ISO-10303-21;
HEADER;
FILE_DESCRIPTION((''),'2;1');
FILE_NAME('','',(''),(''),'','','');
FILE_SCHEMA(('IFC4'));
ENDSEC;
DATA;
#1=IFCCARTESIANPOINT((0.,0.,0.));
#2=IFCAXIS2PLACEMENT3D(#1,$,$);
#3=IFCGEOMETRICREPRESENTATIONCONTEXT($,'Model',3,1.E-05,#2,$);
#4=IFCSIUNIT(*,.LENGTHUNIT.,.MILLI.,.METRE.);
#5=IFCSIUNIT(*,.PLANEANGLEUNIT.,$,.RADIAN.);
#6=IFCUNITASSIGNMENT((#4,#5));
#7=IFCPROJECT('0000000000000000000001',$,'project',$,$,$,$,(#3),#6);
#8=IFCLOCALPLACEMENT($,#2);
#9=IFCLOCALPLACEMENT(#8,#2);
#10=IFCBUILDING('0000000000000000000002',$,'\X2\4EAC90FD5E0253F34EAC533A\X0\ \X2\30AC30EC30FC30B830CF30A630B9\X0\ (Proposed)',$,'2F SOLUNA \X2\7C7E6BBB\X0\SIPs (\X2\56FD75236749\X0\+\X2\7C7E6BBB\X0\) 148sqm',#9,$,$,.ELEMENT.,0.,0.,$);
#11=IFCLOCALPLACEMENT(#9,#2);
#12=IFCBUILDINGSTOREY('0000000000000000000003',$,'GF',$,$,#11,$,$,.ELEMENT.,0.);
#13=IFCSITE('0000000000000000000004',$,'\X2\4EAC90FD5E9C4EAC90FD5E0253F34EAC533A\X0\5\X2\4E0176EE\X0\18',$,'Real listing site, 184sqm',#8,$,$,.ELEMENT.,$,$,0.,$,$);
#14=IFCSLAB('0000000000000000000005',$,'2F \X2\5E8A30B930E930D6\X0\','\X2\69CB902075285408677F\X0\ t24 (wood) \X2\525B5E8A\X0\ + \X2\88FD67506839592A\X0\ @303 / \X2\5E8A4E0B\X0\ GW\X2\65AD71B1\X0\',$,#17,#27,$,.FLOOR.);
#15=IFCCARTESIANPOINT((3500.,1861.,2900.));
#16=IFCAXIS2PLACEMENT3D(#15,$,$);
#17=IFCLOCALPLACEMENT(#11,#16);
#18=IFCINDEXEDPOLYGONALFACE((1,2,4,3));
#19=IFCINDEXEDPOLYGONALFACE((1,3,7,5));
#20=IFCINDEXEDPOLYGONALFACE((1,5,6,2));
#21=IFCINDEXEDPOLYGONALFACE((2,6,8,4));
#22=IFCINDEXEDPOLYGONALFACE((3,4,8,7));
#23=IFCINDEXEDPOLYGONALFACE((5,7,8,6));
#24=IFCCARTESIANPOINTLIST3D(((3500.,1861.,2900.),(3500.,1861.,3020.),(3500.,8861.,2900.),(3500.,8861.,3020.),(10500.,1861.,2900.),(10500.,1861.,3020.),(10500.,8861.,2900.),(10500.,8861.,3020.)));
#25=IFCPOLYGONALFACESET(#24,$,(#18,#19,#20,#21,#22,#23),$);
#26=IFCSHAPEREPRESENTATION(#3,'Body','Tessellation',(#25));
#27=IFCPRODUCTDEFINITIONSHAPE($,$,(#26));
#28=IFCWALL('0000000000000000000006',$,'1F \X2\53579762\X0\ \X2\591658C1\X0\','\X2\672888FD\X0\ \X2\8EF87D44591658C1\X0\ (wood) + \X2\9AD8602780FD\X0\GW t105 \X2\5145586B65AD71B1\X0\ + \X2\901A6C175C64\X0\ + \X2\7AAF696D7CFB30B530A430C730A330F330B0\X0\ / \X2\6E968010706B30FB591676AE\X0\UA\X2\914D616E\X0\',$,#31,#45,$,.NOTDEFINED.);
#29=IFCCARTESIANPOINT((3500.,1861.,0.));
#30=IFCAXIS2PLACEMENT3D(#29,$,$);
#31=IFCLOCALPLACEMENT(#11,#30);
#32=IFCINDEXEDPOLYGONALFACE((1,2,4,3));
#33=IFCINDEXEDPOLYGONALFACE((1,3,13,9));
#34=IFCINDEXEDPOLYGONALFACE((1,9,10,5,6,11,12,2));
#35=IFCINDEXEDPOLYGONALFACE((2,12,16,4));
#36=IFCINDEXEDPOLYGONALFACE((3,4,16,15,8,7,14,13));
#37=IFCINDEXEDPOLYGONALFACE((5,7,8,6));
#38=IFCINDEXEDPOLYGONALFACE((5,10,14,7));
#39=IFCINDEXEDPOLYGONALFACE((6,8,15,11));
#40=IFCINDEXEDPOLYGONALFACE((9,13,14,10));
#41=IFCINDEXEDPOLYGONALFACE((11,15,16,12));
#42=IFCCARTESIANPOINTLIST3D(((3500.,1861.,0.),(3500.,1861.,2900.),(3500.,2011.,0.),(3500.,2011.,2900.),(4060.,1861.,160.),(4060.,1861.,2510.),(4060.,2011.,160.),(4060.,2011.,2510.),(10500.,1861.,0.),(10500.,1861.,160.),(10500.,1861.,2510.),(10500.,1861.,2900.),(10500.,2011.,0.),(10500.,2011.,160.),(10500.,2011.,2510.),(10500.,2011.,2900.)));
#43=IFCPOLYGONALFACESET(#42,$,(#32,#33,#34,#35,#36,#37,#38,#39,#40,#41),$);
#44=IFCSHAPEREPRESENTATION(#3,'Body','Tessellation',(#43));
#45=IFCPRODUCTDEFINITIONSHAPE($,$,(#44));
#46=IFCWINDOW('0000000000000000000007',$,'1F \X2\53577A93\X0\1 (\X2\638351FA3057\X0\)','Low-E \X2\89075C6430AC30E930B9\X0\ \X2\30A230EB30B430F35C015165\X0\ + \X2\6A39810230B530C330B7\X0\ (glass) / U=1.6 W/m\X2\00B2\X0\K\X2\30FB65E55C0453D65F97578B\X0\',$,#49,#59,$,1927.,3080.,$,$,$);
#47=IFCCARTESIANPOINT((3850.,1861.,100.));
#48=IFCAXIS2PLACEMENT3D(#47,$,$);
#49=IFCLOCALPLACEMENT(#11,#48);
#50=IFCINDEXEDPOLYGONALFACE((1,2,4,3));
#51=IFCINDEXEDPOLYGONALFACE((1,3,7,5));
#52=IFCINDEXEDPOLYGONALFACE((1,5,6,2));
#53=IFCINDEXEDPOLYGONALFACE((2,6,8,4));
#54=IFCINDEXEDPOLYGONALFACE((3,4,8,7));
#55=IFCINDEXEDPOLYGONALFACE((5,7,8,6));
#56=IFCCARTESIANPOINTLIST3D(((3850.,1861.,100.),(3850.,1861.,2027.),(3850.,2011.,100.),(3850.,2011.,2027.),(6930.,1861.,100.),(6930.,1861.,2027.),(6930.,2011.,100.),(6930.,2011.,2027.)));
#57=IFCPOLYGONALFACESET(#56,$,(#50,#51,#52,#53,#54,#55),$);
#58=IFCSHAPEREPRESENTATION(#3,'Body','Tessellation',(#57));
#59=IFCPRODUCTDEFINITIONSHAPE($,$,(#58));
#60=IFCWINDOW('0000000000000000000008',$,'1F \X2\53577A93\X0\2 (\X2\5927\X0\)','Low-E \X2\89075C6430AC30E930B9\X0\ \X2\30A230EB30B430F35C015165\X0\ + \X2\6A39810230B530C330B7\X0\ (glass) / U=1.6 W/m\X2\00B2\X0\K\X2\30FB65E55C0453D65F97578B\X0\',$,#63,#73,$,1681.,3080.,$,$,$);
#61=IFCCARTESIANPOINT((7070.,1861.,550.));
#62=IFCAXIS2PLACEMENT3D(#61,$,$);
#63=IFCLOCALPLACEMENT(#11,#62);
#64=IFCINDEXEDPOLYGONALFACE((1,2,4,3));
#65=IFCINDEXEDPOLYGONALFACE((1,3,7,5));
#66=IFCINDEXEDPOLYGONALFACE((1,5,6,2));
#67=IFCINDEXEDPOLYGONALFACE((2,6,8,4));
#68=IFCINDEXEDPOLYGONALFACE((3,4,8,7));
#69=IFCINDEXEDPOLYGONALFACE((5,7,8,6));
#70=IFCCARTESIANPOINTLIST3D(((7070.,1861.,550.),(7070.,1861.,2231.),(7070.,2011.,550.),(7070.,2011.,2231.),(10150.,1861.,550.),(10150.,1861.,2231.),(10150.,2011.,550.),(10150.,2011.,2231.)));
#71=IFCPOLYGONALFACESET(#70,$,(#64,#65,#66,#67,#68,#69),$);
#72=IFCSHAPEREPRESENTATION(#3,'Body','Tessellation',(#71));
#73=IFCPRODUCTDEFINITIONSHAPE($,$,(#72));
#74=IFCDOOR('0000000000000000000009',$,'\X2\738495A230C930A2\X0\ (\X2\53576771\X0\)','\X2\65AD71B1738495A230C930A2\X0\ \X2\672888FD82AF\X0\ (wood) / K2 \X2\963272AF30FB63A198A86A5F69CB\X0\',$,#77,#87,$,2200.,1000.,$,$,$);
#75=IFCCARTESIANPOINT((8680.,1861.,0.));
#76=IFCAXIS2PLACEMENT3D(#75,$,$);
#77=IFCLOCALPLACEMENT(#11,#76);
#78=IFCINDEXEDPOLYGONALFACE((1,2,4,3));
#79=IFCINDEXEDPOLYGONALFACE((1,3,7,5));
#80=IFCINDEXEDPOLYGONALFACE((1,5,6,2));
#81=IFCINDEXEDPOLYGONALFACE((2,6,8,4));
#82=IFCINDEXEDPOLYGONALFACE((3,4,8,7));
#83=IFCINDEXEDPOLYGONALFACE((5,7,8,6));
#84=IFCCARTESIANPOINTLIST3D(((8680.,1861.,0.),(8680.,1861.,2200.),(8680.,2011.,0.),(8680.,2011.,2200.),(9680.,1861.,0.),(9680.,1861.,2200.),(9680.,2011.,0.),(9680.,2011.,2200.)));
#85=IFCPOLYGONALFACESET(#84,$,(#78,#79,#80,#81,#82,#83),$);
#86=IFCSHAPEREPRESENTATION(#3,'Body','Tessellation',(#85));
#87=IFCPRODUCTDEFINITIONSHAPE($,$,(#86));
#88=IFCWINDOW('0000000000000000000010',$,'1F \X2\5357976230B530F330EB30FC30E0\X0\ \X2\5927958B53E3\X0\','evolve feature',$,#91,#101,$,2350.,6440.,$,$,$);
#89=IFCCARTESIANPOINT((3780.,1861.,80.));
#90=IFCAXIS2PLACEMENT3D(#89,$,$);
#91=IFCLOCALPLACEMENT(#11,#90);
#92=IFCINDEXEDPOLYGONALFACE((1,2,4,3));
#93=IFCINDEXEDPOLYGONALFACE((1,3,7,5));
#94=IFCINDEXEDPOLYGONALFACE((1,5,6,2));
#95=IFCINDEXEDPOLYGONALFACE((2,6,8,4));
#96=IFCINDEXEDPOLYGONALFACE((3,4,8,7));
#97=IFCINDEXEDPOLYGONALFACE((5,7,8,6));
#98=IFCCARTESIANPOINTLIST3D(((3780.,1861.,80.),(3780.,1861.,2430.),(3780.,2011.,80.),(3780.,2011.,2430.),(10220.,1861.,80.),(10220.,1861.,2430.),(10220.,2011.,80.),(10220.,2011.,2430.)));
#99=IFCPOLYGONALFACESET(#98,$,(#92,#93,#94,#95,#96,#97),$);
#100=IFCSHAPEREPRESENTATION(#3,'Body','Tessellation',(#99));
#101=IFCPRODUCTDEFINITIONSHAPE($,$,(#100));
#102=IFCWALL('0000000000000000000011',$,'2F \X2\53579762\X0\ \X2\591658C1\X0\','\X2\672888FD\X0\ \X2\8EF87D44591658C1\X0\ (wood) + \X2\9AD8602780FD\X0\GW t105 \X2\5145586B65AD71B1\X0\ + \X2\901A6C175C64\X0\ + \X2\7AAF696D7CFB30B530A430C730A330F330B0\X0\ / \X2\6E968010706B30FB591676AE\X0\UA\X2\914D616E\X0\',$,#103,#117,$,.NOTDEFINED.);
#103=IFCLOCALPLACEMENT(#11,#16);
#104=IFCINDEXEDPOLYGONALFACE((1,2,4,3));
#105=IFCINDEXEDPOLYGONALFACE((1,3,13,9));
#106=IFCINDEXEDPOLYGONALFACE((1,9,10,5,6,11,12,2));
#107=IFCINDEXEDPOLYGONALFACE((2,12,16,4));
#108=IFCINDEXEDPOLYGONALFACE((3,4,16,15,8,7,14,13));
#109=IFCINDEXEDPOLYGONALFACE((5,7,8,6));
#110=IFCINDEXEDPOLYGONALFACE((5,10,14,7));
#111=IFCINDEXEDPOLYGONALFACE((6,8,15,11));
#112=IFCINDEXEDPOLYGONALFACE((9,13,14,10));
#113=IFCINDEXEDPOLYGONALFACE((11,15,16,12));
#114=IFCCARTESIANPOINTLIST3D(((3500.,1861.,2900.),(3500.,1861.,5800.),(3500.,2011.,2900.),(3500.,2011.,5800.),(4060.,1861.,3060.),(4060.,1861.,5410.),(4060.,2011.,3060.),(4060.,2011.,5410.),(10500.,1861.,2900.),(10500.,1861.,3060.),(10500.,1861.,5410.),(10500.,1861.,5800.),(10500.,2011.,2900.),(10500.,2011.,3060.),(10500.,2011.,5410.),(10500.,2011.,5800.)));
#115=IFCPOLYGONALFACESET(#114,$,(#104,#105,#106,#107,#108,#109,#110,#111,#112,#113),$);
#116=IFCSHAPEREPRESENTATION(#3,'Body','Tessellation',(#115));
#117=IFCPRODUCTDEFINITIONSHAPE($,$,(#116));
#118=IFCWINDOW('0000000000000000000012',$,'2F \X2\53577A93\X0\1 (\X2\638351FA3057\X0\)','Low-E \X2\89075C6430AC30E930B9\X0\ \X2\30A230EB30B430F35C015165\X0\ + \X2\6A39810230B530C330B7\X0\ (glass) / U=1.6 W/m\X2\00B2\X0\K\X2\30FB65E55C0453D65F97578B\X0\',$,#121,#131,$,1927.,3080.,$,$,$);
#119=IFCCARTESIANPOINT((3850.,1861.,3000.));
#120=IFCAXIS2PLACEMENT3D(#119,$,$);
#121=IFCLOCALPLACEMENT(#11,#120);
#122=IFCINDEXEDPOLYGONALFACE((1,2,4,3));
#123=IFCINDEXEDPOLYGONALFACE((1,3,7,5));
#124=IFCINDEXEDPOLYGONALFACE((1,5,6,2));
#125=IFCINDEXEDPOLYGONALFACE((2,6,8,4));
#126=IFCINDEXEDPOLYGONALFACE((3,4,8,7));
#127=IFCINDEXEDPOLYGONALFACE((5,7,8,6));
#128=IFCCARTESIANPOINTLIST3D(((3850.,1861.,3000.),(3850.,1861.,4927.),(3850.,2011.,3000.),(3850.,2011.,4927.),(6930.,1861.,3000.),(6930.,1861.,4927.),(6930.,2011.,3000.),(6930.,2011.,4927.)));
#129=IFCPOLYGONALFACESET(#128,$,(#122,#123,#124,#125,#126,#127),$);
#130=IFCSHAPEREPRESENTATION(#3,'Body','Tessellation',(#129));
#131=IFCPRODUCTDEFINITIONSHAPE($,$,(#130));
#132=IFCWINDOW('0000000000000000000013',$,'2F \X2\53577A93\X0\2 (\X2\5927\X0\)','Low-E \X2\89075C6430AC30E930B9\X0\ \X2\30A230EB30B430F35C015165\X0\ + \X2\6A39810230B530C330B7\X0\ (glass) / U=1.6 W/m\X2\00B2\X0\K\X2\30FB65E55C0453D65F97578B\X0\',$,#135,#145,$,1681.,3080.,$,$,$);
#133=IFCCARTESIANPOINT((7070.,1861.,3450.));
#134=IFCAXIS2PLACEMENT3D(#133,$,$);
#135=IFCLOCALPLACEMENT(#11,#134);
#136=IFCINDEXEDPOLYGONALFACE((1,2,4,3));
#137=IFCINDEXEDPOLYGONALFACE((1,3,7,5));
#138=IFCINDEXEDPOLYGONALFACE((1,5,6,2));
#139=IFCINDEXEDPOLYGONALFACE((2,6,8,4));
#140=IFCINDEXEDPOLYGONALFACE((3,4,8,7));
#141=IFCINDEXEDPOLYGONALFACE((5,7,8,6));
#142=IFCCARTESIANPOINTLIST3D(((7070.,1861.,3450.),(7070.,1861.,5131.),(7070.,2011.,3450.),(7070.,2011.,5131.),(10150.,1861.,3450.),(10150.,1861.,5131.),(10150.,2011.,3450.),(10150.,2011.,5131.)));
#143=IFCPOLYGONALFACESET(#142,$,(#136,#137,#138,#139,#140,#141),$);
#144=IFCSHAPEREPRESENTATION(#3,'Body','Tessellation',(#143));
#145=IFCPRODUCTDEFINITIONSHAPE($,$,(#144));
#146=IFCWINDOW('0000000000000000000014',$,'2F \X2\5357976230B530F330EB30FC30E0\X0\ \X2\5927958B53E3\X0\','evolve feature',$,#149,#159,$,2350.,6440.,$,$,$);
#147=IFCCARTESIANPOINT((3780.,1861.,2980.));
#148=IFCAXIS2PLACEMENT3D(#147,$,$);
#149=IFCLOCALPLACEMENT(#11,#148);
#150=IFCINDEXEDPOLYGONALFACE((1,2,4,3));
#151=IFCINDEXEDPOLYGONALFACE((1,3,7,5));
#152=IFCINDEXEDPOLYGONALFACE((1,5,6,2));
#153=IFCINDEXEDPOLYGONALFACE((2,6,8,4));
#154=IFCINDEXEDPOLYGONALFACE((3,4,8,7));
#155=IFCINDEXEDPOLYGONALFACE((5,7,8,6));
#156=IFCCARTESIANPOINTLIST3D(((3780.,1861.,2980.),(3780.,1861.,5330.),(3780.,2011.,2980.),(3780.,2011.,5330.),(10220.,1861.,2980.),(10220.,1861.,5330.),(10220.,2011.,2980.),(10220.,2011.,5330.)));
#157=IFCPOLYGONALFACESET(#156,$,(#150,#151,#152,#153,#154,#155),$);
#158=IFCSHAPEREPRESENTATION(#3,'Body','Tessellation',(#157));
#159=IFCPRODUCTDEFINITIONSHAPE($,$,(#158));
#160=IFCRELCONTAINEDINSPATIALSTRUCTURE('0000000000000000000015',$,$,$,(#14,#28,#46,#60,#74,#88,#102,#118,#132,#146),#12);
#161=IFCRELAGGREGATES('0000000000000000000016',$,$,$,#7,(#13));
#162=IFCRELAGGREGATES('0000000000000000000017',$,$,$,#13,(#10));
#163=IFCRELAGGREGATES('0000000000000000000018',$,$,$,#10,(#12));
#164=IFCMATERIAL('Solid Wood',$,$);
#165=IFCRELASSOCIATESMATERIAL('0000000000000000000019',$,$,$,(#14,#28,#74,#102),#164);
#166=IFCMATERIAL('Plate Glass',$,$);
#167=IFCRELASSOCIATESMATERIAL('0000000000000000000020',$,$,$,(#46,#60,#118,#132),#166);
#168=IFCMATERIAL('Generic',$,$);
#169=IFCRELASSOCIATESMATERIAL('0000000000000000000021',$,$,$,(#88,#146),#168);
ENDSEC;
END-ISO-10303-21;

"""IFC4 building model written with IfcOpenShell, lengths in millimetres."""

from ifc_helpers import new_model, si_unit, frame, frame_2d, origin, place, context, project, spatial, rectangle, extrude, material, element, fill, save


model = new_model("IFC4")

# Units and contexts
model_context = context("Model", 3, precision=1e-05, world=origin())
ifc_project = project(units=[si_unit("LENGTHUNIT", "METRE", prefix="MILLI"), si_unit("PLANEANGLEUNIT", "RADIAN")], contexts=[model_context])

# Site, building, storey
site_placement = place(None, origin())
site = spatial("IfcSite", under=ifc_project, at=site_placement, Name="京都府京都市右京区5丁目18", ObjectType="Real listing site, 184sqm", CompositionType="ELEMENT", RefElevation=0.0)
building_placement = place(site_placement, origin())
building = spatial("IfcBuilding", under=site, at=building_placement, Name="京都市右京区 ガレージハウス (Proposed)", ObjectType="2F SOLUNA 籾殻SIPs (国産杉+籾殻) 148sqm", CompositionType="ELEMENT", ElevationOfRefHeight=0.0, ElevationOfTerrain=0.0)
storey_placement = place(building_placement, origin())
storey = spatial("IfcBuildingStorey", under=building, at=storey_placement, Name="GF", CompositionType="ELEMENT", Elevation=0.0)

# Slab
ifc_material_1 = material(Name="Solid Wood")
slab_1_placement = place(storey_placement, frame((3500.0, 1861.0, 2900.0)))
element("IfcSlab", 1, at=slab_1_placement, inside=storey, material=ifc_material_1, Name="2F 床スラブ", Description="構造用合板 t24 (wood) 剛床 + 製材根太 @303 / 床下 GW断熱", PredefinedType="FLOOR", context=model_context, shape_type="SweptSolid", body=[
    extrude(rectangle(XDim=7000.0, YDim=7000.0, at=frame_2d((3500.0, 3500.0))), frame((3500.0, 1861.0, 2900.0)), (0.0, 0.0, 1.0), 120.0),
])
ifc_material_2 = material(Name="Generic")

# Wall, openings, windows, door
wall_1_placement = place(storey_placement, frame((3500.0, 1861.0, 0.0)))
wall_1 = element("IfcWall", 2, at=wall_1_placement, inside=storey, material=ifc_material_1, Name="1F 南面 外壁", Description="木製 軸組外壁 (wood) + 高性能GW t105 充填断熱 + 通気層 + 窯業系サイディング / 準耐火・外皮UA配慮", PredefinedType="NOTDEFINED", context=model_context, shape_type="SweptSolid", body=[
    extrude(rectangle(XDim=7000.0, YDim=150.0, at=frame_2d((3500.0, 75.0))), frame((3500.0, 1861.0, 0.0)), (0.0, 0.0, 1.0), 2900.0),
])
opening_1_placement = place(storey_placement, frame((3850.0, 1861.0, 100.0)))
opening_1 = element("IfcOpeningElement", 3, at=opening_1_placement, cuts=wall_1, PredefinedType="NOTDEFINED", context=model_context, shape_type="SweptSolid", body=[
    extrude(rectangle(XDim=3080.0, YDim=150.0, at=frame_2d((1540.0, 75.0))), frame((3850.0, 1861.0, 100.0)), (0.0, 0.0, 1.0), 1927.0),
])
opening_2_placement = place(storey_placement, frame((7070.0, 1861.0, 550.0)))
opening_2 = element("IfcOpeningElement", 4, at=opening_2_placement, cuts=wall_1, PredefinedType="NOTDEFINED", context=model_context, shape_type="SweptSolid", body=[
    extrude(rectangle(XDim=3080.0, YDim=150.0, at=frame_2d((1540.0, 75.0))), frame((7070.0, 1861.0, 550.0)), (0.0, 0.0, 1.0), 1681.0),
])
opening_3_placement = place(storey_placement, frame((8680.0, 1861.0, 0.0)))
opening_3 = element("IfcOpeningElement", 5, at=opening_3_placement, cuts=wall_1, PredefinedType="NOTDEFINED", context=model_context, shape_type="SweptSolid", body=[
    extrude(rectangle(XDim=1000.0, YDim=150.0, at=frame_2d((500.0, 75.0))), frame((8680.0, 1861.0, 0.0)), (0.0, 0.0, 1.0), 2200.0),
])
opening_4_placement = place(storey_placement, frame((3780.0, 1861.0, 80.0)))
opening_4 = element("IfcOpeningElement", 6, at=opening_4_placement, cuts=wall_1, PredefinedType="NOTDEFINED", context=model_context, shape_type="SweptSolid", body=[
    extrude(rectangle(XDim=6440.0, YDim=150.0, at=frame_2d((3220.0, 75.0))), frame((3780.0, 1861.0, 80.0)), (0.0, 0.0, 1.0), 2350.0),
])
ifc_material_3 = material(Name="Plate Glass")
window_1_placement = place(storey_placement, frame((3850.0, 1861.0, 100.0)))
window_1 = element("IfcWindow", 7, at=window_1_placement, inside=storey, material=ifc_material_3, Name="1F 南窓1 (掃出し)", Description="Low-E 複層ガラス アルゴン封入 + 樹脂サッシ (glass) / U=1.6 W/m²K・日射取得型", OverallHeight=1927.0, OverallWidth=3080.0, context=model_context, shape_type="SweptSolid", body=[
    extrude(rectangle(XDim=3080.0, YDim=150.0, at=frame_2d((1540.0, 75.0))), frame((3850.0, 1861.0, 100.0)), (0.0, 0.0, 1.0), 1927.0),
])
fill(opening_1, window_1)
window_2_placement = place(storey_placement, frame((7070.0, 1861.0, 550.0)))
window_2 = element("IfcWindow", 8, at=window_2_placement, inside=storey, material=ifc_material_3, Name="1F 南窓2 (大)", Description="Low-E 複層ガラス アルゴン封入 + 樹脂サッシ (glass) / U=1.6 W/m²K・日射取得型", OverallHeight=1681.0, OverallWidth=3080.0, context=model_context, shape_type="SweptSolid", body=[
    extrude(rectangle(XDim=3080.0, YDim=150.0, at=frame_2d((1540.0, 75.0))), frame((7070.0, 1861.0, 550.0)), (0.0, 0.0, 1.0), 1681.0),
])
fill(opening_2, window_2)
door_placement = place(storey_placement, frame((8680.0, 1861.0, 0.0)))
door = element("IfcDoor", 9, at=door_placement, inside=storey, material=ifc_material_1, Name="玄関ドア (南東)", Description="断熱玄関ドア 木製芯 (wood) / K2 防犯・採風機構", OverallHeight=2200.0, OverallWidth=1000.0, context=model_context, shape_type="SweptSolid", body=[
    extrude(rectangle(XDim=1000.0, YDim=150.0, at=frame_2d((500.0, 75.0))), frame((8680.0, 1861.0, 0.0)), (0.0, 0.0, 1.0), 2200.0),
])
fill(opening_3, door)
window_3_placement = place(storey_placement, frame((3780.0, 1861.0, 80.0)))
window_3 = element("IfcWindow", 10, at=window_3_placement, inside=storey, material=ifc_material_2, Name="1F 南面サンルーム 大開口", Description="evolve feature", OverallHeight=2350.0, OverallWidth=6440.0, context=model_context, shape_type="SweptSolid", body=[
    extrude(rectangle(XDim=6440.0, YDim=150.0, at=frame_2d((3220.0, 75.0))), frame((3780.0, 1861.0, 80.0)), (0.0, 0.0, 1.0), 2350.0),
])
fill(opening_4, window_3)

# Wall, openings, windows
wall_2_placement = place(storey_placement, frame((3500.0, 1861.0, 2900.0)))
wall_2 = element("IfcWall", 11, at=wall_2_placement, inside=storey, material=ifc_material_1, Name="2F 南面 外壁", Description="木製 軸組外壁 (wood) + 高性能GW t105 充填断熱 + 通気層 + 窯業系サイディング / 準耐火・外皮UA配慮", PredefinedType="NOTDEFINED", context=model_context, shape_type="SweptSolid", body=[
    extrude(rectangle(XDim=7000.0, YDim=150.0, at=frame_2d((3500.0, 75.0))), frame((3500.0, 1861.0, 2900.0)), (0.0, 0.0, 1.0), 2900.0),
])
opening_5_placement = place(storey_placement, frame((3850.0, 1861.0, 3000.0)))
opening_5 = element("IfcOpeningElement", 12, at=opening_5_placement, cuts=wall_2, PredefinedType="NOTDEFINED", context=model_context, shape_type="SweptSolid", body=[
    extrude(rectangle(XDim=3080.0, YDim=150.0, at=frame_2d((1540.0, 75.0))), frame((3850.0, 1861.0, 3000.0)), (0.0, 0.0, 1.0), 1927.0),
])
opening_6_placement = place(storey_placement, frame((7070.0, 1861.0, 3450.0)))
opening_6 = element("IfcOpeningElement", 13, at=opening_6_placement, cuts=wall_2, PredefinedType="NOTDEFINED", context=model_context, shape_type="SweptSolid", body=[
    extrude(rectangle(XDim=3080.0, YDim=150.0, at=frame_2d((1540.0, 75.0))), frame((7070.0, 1861.0, 3450.0)), (0.0, 0.0, 1.0), 1681.0),
])
opening_7_placement = place(storey_placement, frame((3780.0, 1861.0, 2980.0)))
opening_7 = element("IfcOpeningElement", 14, at=opening_7_placement, cuts=wall_2, PredefinedType="NOTDEFINED", context=model_context, shape_type="SweptSolid", body=[
    extrude(rectangle(XDim=6440.0, YDim=150.0, at=frame_2d((3220.0, 75.0))), frame((3780.0, 1861.0, 2980.0)), (0.0, 0.0, 1.0), 2350.0),
])
window_4_placement = place(storey_placement, frame((3850.0, 1861.0, 3000.0)))
window_4 = element("IfcWindow", 15, at=window_4_placement, inside=storey, material=ifc_material_3, Name="2F 南窓1 (掃出し)", Description="Low-E 複層ガラス アルゴン封入 + 樹脂サッシ (glass) / U=1.6 W/m²K・日射取得型", OverallHeight=1927.0, OverallWidth=3080.0, context=model_context, shape_type="SweptSolid", body=[
    extrude(rectangle(XDim=3080.0, YDim=150.0, at=frame_2d((1540.0, 75.0))), frame((3850.0, 1861.0, 3000.0)), (0.0, 0.0, 1.0), 1927.0),
])
fill(opening_5, window_4)
window_5_placement = place(storey_placement, frame((7070.0, 1861.0, 3450.0)))
window_5 = element("IfcWindow", 16, at=window_5_placement, inside=storey, material=ifc_material_3, Name="2F 南窓2 (大)", Description="Low-E 複層ガラス アルゴン封入 + 樹脂サッシ (glass) / U=1.6 W/m²K・日射取得型", OverallHeight=1681.0, OverallWidth=3080.0, context=model_context, shape_type="SweptSolid", body=[
    extrude(rectangle(XDim=3080.0, YDim=150.0, at=frame_2d((1540.0, 75.0))), frame((7070.0, 1861.0, 3450.0)), (0.0, 0.0, 1.0), 1681.0),
])
fill(opening_6, window_5)
window_6_placement = place(storey_placement, frame((3780.0, 1861.0, 2980.0)))
window_6 = element("IfcWindow", 17, at=window_6_placement, inside=storey, material=ifc_material_2, Name="2F 南面サンルーム 大開口", Description="evolve feature", OverallHeight=2350.0, OverallWidth=6440.0, context=model_context, shape_type="SweptSolid", body=[
    extrude(rectangle(XDim=6440.0, YDim=150.0, at=frame_2d((3220.0, 75.0))), frame((3780.0, 1861.0, 2980.0)), (0.0, 0.0, 1.0), 2350.0),
])
fill(opening_7, window_6)

save(model, "model.ifc")
